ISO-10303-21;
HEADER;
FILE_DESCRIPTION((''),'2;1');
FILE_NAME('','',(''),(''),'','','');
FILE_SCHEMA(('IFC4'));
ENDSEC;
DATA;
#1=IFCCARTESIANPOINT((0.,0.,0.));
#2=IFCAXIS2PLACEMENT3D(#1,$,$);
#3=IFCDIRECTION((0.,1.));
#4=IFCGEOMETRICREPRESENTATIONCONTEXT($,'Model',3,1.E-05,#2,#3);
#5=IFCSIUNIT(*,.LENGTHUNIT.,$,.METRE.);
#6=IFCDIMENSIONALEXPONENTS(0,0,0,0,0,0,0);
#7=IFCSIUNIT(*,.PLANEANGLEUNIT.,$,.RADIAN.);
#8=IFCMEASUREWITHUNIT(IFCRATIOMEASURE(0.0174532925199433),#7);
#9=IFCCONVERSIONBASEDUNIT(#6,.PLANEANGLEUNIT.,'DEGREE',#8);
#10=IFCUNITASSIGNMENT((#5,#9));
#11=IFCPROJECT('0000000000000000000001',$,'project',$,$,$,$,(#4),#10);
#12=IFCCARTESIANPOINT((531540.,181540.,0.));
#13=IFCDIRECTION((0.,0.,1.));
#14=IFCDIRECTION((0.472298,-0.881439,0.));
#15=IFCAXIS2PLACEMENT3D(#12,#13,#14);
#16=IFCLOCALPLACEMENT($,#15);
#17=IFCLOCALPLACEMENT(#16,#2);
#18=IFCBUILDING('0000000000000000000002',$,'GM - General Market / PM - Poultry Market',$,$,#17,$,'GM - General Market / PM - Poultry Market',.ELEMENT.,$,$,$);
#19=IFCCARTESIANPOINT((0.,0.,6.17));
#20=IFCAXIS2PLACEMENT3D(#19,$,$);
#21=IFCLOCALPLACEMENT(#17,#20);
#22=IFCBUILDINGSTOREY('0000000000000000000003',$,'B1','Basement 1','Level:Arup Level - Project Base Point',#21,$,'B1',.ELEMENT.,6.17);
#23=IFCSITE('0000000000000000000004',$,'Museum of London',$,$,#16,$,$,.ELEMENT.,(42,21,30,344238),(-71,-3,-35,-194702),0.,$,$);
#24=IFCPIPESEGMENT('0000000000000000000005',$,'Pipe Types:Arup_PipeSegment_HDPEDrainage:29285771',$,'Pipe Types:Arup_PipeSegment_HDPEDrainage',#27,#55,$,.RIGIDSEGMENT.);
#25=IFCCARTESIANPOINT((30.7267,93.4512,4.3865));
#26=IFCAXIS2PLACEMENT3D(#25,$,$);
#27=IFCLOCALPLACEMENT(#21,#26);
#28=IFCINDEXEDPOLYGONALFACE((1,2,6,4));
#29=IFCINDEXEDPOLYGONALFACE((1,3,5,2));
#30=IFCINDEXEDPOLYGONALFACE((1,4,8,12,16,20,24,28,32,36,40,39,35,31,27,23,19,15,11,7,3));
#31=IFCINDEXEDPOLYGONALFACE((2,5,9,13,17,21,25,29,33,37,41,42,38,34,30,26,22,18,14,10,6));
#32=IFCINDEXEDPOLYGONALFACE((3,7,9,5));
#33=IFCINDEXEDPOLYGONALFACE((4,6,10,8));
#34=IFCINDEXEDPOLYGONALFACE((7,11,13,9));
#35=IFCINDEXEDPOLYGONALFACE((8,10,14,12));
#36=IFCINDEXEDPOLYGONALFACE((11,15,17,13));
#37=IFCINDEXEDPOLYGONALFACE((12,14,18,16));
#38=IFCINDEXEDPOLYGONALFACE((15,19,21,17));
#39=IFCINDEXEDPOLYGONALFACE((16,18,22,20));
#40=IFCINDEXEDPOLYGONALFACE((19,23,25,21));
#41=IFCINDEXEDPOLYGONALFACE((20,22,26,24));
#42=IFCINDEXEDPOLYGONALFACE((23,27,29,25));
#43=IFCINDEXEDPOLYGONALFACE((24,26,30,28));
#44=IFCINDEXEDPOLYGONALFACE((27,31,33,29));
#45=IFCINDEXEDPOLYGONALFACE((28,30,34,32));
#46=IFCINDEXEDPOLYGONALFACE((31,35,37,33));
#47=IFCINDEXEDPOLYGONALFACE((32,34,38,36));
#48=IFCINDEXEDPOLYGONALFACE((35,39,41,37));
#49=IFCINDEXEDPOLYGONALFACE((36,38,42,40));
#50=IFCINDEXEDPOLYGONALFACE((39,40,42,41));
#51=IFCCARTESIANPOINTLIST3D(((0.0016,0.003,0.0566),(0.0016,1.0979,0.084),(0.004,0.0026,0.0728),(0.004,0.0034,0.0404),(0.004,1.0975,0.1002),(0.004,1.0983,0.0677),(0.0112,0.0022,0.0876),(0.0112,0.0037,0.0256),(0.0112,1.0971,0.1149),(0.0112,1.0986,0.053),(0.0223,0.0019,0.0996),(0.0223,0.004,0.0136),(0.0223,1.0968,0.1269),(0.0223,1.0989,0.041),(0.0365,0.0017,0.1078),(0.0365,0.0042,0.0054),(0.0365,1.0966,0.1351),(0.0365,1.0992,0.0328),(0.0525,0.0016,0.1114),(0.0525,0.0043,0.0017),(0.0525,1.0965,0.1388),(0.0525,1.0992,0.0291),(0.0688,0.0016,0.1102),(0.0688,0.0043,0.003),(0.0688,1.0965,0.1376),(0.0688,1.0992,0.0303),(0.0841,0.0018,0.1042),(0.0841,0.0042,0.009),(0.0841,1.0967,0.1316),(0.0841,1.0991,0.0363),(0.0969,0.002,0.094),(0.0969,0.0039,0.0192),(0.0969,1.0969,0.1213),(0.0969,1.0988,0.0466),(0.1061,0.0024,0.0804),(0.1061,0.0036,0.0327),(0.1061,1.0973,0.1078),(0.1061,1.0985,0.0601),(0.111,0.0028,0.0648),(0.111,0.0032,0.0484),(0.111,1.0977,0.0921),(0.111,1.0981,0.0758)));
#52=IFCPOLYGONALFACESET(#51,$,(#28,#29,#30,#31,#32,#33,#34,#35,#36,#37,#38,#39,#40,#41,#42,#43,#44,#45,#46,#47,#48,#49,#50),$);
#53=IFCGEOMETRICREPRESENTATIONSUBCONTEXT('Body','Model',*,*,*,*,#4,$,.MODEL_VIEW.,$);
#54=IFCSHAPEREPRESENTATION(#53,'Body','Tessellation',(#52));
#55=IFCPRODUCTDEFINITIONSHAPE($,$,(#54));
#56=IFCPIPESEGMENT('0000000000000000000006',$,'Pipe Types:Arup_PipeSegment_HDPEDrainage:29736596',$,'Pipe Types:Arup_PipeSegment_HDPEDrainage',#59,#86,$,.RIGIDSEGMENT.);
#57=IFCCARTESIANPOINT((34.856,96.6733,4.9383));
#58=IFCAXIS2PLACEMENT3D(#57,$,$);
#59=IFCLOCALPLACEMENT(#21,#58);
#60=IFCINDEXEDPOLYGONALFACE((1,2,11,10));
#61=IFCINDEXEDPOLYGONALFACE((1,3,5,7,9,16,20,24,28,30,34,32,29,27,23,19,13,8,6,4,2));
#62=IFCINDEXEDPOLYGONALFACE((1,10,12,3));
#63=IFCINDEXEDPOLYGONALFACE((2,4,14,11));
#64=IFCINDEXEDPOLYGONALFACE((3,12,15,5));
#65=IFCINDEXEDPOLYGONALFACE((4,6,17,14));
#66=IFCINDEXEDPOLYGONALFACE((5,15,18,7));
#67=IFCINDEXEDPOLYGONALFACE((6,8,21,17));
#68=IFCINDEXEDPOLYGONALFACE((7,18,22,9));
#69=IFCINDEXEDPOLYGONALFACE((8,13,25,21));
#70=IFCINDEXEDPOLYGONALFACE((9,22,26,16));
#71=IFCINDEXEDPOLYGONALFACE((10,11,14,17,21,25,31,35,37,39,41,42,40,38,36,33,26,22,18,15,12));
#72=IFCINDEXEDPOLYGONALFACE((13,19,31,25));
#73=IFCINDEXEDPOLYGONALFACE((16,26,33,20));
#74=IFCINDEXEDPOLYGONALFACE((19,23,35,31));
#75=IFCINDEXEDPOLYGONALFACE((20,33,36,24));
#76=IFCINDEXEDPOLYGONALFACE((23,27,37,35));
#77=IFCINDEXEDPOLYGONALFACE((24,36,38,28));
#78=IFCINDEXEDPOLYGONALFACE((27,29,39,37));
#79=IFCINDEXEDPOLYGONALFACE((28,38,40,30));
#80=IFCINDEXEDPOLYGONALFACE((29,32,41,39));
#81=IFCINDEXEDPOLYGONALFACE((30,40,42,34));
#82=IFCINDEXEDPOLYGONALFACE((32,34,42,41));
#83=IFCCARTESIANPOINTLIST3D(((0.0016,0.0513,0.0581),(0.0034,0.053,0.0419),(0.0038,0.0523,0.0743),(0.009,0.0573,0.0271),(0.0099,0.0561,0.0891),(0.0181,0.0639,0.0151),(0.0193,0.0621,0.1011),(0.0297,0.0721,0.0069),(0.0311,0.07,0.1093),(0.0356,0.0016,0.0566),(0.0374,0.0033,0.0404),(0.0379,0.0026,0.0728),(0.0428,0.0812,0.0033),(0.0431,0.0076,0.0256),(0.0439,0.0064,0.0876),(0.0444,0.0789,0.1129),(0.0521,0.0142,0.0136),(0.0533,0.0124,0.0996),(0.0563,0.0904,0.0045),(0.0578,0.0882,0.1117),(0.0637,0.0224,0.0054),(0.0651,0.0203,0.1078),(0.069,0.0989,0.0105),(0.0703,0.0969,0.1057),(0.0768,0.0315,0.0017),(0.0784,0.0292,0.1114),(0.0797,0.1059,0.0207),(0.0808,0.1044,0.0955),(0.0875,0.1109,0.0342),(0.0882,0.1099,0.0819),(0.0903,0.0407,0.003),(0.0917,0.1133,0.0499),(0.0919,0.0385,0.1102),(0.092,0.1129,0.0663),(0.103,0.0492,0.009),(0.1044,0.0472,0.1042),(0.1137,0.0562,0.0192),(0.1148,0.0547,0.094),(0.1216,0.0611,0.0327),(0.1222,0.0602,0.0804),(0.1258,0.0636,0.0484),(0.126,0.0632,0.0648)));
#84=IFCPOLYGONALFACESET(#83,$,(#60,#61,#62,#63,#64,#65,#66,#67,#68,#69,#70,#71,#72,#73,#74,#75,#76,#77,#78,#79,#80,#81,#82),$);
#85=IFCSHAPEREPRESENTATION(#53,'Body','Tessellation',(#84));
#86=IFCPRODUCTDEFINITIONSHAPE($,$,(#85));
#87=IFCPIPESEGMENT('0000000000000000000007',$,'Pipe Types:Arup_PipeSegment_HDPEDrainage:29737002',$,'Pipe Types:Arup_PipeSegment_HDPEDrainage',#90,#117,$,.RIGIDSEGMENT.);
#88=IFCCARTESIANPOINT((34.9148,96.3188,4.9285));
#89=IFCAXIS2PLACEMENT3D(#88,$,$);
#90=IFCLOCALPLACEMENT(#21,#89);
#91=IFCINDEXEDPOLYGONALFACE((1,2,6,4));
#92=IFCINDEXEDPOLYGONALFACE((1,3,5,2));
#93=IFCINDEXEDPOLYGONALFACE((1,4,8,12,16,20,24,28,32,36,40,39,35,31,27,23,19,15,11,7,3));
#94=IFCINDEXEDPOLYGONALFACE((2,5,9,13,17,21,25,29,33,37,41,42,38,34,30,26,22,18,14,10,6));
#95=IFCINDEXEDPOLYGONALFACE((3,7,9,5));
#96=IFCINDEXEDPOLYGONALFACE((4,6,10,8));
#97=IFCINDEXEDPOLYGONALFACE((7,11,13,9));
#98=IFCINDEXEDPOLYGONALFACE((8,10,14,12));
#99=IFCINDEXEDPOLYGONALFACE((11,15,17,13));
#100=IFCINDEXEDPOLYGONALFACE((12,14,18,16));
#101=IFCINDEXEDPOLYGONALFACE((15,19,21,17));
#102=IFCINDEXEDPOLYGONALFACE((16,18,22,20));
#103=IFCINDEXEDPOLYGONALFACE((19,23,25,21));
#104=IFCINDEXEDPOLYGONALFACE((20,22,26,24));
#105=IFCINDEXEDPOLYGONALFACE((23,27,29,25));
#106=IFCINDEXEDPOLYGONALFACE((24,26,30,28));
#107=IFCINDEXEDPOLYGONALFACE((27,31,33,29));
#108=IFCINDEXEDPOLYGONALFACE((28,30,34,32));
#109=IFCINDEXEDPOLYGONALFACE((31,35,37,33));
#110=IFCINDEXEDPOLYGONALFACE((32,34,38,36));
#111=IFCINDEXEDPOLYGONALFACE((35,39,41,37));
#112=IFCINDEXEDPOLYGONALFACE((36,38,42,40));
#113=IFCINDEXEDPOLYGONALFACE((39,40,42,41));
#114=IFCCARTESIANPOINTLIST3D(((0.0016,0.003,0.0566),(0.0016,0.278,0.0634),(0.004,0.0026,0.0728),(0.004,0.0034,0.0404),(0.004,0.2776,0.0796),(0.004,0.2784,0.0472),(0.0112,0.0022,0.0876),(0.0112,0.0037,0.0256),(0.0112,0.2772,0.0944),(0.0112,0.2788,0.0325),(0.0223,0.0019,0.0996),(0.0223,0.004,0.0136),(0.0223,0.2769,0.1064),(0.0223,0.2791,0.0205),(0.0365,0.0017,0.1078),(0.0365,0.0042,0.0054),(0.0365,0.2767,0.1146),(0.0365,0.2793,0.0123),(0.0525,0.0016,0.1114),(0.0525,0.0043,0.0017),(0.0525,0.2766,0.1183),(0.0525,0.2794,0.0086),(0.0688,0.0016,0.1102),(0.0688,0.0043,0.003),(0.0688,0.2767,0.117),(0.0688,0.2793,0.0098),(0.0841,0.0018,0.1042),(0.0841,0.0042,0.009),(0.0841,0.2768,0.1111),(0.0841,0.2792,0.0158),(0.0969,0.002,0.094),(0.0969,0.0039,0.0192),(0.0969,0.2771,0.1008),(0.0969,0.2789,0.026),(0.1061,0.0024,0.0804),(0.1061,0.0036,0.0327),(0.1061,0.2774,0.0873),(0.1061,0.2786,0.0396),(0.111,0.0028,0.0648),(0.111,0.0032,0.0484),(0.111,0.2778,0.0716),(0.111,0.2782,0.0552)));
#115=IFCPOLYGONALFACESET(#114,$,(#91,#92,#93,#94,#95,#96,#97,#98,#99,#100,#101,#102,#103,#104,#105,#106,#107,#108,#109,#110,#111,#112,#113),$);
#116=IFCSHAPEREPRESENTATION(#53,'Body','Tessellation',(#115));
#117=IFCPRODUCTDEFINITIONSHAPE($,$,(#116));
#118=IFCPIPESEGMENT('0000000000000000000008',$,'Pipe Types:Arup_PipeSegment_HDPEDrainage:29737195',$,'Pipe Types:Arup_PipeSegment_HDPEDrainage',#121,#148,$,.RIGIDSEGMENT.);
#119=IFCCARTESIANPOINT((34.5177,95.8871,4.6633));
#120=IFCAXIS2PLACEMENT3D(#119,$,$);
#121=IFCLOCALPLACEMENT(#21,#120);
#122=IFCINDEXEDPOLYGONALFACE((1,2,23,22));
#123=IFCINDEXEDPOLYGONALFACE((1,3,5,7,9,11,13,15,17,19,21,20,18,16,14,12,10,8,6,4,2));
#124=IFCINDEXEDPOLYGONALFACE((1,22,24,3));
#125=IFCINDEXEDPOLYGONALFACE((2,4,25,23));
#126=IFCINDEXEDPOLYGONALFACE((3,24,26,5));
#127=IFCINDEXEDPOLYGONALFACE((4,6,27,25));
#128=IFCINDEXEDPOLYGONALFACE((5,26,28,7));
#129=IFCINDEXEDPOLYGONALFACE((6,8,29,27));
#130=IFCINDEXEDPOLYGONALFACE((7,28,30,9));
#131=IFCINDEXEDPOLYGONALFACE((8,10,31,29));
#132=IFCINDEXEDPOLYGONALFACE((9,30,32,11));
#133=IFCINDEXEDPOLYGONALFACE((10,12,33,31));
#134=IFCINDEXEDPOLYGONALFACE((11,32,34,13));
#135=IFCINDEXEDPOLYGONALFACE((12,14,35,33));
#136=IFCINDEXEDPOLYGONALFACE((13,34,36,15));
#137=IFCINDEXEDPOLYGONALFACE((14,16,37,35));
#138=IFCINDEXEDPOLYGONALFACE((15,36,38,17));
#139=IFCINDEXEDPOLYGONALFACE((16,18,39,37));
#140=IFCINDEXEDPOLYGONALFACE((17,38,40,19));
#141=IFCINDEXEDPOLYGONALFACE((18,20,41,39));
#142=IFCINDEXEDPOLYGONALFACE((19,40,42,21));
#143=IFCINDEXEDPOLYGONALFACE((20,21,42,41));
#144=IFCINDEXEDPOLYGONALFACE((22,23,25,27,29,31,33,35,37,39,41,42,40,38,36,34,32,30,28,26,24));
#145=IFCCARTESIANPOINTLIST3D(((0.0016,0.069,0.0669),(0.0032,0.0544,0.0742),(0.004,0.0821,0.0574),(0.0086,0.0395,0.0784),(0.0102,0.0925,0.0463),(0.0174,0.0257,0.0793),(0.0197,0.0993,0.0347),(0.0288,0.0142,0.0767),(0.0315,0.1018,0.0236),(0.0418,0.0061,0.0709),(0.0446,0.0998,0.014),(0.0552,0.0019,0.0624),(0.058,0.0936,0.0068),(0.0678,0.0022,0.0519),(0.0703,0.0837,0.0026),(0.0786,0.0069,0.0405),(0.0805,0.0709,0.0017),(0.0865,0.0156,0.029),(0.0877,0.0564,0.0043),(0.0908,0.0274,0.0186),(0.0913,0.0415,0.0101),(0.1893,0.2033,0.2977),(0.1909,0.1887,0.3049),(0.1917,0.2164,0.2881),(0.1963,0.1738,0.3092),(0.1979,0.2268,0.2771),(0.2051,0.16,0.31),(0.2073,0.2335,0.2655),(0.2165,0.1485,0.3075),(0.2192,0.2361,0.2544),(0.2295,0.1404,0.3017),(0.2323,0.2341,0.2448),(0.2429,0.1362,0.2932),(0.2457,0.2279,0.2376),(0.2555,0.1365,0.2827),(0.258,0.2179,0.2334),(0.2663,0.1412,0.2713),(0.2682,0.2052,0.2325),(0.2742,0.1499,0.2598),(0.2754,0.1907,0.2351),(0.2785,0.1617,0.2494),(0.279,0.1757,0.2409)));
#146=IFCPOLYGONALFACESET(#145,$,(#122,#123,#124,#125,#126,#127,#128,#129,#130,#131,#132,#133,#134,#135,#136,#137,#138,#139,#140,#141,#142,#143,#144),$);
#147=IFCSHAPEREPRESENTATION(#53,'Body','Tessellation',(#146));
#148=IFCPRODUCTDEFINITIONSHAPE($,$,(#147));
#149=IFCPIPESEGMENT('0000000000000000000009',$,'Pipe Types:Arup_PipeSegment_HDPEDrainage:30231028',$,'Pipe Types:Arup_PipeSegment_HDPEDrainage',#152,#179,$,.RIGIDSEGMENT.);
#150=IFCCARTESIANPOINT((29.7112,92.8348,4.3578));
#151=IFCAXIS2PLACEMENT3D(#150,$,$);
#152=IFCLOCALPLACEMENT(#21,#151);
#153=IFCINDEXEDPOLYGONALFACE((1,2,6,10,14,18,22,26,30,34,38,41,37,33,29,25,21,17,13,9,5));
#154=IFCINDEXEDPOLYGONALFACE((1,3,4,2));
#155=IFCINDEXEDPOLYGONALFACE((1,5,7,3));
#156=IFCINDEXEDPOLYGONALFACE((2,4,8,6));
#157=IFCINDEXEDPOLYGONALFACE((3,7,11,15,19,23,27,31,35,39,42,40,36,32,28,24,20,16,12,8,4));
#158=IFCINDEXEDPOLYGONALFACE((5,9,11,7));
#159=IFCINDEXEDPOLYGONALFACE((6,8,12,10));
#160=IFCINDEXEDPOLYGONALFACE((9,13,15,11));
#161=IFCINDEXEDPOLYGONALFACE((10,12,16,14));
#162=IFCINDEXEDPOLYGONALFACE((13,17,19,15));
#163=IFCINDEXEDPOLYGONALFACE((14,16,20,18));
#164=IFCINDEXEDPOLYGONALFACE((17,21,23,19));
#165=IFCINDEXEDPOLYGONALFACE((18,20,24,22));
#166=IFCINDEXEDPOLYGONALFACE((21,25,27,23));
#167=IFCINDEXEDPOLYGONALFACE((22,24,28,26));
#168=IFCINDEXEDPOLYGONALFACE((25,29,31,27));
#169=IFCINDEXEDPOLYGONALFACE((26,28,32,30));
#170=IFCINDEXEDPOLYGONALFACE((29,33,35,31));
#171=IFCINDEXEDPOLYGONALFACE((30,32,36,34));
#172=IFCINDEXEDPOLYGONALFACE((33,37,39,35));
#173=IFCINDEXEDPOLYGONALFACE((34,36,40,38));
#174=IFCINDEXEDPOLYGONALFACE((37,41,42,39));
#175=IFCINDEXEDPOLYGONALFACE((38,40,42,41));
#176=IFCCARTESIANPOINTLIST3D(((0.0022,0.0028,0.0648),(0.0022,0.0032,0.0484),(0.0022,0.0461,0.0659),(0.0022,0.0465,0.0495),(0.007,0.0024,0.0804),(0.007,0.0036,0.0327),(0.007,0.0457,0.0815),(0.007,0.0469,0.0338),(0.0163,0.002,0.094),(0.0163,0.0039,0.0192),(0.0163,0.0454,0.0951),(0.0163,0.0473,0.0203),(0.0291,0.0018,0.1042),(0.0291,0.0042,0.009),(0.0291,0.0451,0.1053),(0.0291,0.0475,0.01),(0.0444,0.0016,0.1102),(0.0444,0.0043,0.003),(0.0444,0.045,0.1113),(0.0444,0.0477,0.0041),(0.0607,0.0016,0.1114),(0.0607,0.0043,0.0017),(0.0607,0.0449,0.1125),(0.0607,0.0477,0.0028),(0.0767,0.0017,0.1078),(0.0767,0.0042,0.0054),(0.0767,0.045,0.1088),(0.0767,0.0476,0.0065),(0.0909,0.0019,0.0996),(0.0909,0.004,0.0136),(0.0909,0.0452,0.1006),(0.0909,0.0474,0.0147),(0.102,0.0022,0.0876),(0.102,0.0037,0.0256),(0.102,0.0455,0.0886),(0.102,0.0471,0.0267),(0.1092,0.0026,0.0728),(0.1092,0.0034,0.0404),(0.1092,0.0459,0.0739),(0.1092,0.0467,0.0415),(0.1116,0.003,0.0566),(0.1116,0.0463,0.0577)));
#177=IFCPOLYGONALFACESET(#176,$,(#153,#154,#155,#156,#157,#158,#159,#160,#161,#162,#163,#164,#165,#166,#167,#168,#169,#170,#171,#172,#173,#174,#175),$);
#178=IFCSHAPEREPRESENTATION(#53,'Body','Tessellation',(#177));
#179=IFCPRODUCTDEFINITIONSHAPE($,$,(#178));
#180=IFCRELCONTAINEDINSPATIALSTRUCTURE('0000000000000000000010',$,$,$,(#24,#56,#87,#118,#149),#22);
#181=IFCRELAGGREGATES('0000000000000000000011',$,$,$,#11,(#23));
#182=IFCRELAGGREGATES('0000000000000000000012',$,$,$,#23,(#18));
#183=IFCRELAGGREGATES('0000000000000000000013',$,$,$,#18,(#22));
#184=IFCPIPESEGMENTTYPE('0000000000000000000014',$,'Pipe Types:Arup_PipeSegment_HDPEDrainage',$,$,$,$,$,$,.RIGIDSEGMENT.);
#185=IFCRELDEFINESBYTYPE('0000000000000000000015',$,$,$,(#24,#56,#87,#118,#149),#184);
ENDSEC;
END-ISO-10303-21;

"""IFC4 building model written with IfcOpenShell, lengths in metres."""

from ifc_helpers import new_model, entity, si_unit, converted_unit, direction, frame, frame_2d, origin, origin_2d_with_axis, place, context, subcontext, project, spatial, circle, extrude, type_object, element, save


model = new_model("IFC4")

# Units and contexts
model_context = context("Model", 3, precision=1e-05, world=origin(), true_north=direction((0.0, 1.0)))
body_context = subcontext(model_context, "Body", "Model", "MODEL_VIEW")
ifc_project = project(units=[si_unit("LENGTHUNIT", "METRE"), converted_unit("PLANEANGLEUNIT", "DEGREE", entity("IfcRatioMeasure", 0.0174532925199433), si_unit("PLANEANGLEUNIT", "RADIAN"), dimensions=[0, 0, 0, 0, 0, 0, 0])], contexts=[model_context])

# Site, building, storey
site_placement = place(None, frame((531540.0, 181540.0, 0.0), z_axis=(0.0, 0.0, 1.0), x_axis=(0.472298, -0.881439, 0.0)))
site = spatial("IfcSite", under=ifc_project, at=site_placement, Name="Museum of London", CompositionType="ELEMENT", RefLatitude=(42, 21, 30, 344238), RefLongitude=(-71, -3, -35, -194702), RefElevation=0.0)
building_placement = place(site_placement, origin())
building = spatial("IfcBuilding", under=site, at=building_placement, Name="GM - General Market / PM - Poultry Market", LongName="GM - General Market / PM - Poultry Market", CompositionType="ELEMENT")
storey_placement = place(building_placement, frame((0.0, 0.0, 6.17)))
storey = spatial("IfcBuildingStorey", under=building, at=storey_placement, Name="B1", Description="Basement 1", ObjectType="Level:Arup Level - Project Base Point", LongName="B1", CompositionType="ELEMENT", Elevation=6.17)

# Pipe segments
pipe_segment_type_1 = type_object("IfcPipeSegmentType", Name="Pipe Types:Arup_PipeSegment_HDPEDrainage", PredefinedType="RIGIDSEGMENT")
pipe_segment_1_placement = place(storey_placement, frame((30.7267, 93.4512, 4.3865)))
element("IfcPipeSegment", 1, at=pipe_segment_1_placement, inside=storey, type_object=pipe_segment_type_1, Name="Pipe Types:Arup_PipeSegment_HDPEDrainage:29285771", ObjectType="Pipe Types:Arup_PipeSegment_HDPEDrainage", PredefinedType="RIGIDSEGMENT", context=body_context, shape_type="SweptSolid", body=[
    extrude(circle(Radius=0.055, at=frame_2d((0.0, 0.0), x_axis=(1.0, 0.0))), frame((0.0566, 0.003, 0.0566), z_axis=(0.0, 0.999688, 0.024992), x_axis=(-1.0, 0.0, 0.0)), (0.0, 0.0, 1.0), 1.0952),
])
pipe_segment_2_placement = place(storey_placement, frame((34.856, 96.6733, 4.9383)))
element("IfcPipeSegment", 2, at=pipe_segment_2_placement, inside=storey, type_object=pipe_segment_type_1, Name="Pipe Types:Arup_PipeSegment_HDPEDrainage:29736596", ObjectType="Pipe Types:Arup_PipeSegment_HDPEDrainage", PredefinedType="RIGIDSEGMENT", context=body_context, shape_type="SweptSolid", body=[
    extrude(circle(Radius=0.055, at=frame_2d((0.0, 0.0), x_axis=(1.0, 0.0))), frame((0.081, 0.0327, 0.0566), z_axis=(-0.564722, 0.824903, 0.024992), x_axis=(-0.82516, -0.564899, 0.0)), (0.0, 0.0, 1.0), 0.0603),
])
pipe_segment_3_placement = place(storey_placement, frame((34.9148, 96.3188, 4.9285)))
element("IfcPipeSegment", 3, at=pipe_segment_3_placement, inside=storey, type_object=pipe_segment_type_1, Name="Pipe Types:Arup_PipeSegment_HDPEDrainage:29737002", ObjectType="Pipe Types:Arup_PipeSegment_HDPEDrainage", PredefinedType="RIGIDSEGMENT", context=body_context, shape_type="SweptSolid", body=[
    extrude(circle(Radius=0.055, at=frame_2d((0.0, 0.0), x_axis=(1.0, 0.0))), frame((0.0566, 0.003, 0.0566), z_axis=(0.0, 0.999689, 0.024955), x_axis=(-1.0, 0.0, 0.0)), (0.0, 0.0, 1.0), 0.2751),
])
pipe_segment_4_placement = place(storey_placement, frame((34.5177, 95.8871, 4.6633)))
element("IfcPipeSegment", 4, at=pipe_segment_4_placement, inside=storey, type_object=pipe_segment_type_1, Name="Pipe Types:Arup_PipeSegment_HDPEDrainage:29737195", ObjectType="Pipe Types:Arup_PipeSegment_HDPEDrainage", PredefinedType="RIGIDSEGMENT", context=body_context, shape_type="SweptSolid", body=[
    extrude(circle(Radius=0.055, at=origin_2d_with_axis()), frame((0.0466, 0.0516, 0.0405), z_axis=(0.575078, 0.411443, 0.707107), x_axis=(0.581869, -0.813283, 0.0)), (0.0, 0.0, 1.0), 0.3264),
])
pipe_segment_5_placement = place(storey_placement, frame((29.7112, 92.8348, 4.3578)))
element("IfcPipeSegment", 5, at=pipe_segment_5_placement, inside=storey, type_object=pipe_segment_type_1, Name="Pipe Types:Arup_PipeSegment_HDPEDrainage:30231028", ObjectType="Pipe Types:Arup_PipeSegment_HDPEDrainage", PredefinedType="RIGIDSEGMENT", context=body_context, shape_type="SweptSolid", body=[
    extrude(circle(Radius=0.055, at=origin_2d_with_axis()), frame((0.0566, 0.003, 0.0566), z_axis=(0.0, 0.999688, 0.024992), x_axis=(1.0, 0.0, 0.0)), (0.0, 0.0, 1.0), 0.0434),
])

save(model, "model.ifc")
